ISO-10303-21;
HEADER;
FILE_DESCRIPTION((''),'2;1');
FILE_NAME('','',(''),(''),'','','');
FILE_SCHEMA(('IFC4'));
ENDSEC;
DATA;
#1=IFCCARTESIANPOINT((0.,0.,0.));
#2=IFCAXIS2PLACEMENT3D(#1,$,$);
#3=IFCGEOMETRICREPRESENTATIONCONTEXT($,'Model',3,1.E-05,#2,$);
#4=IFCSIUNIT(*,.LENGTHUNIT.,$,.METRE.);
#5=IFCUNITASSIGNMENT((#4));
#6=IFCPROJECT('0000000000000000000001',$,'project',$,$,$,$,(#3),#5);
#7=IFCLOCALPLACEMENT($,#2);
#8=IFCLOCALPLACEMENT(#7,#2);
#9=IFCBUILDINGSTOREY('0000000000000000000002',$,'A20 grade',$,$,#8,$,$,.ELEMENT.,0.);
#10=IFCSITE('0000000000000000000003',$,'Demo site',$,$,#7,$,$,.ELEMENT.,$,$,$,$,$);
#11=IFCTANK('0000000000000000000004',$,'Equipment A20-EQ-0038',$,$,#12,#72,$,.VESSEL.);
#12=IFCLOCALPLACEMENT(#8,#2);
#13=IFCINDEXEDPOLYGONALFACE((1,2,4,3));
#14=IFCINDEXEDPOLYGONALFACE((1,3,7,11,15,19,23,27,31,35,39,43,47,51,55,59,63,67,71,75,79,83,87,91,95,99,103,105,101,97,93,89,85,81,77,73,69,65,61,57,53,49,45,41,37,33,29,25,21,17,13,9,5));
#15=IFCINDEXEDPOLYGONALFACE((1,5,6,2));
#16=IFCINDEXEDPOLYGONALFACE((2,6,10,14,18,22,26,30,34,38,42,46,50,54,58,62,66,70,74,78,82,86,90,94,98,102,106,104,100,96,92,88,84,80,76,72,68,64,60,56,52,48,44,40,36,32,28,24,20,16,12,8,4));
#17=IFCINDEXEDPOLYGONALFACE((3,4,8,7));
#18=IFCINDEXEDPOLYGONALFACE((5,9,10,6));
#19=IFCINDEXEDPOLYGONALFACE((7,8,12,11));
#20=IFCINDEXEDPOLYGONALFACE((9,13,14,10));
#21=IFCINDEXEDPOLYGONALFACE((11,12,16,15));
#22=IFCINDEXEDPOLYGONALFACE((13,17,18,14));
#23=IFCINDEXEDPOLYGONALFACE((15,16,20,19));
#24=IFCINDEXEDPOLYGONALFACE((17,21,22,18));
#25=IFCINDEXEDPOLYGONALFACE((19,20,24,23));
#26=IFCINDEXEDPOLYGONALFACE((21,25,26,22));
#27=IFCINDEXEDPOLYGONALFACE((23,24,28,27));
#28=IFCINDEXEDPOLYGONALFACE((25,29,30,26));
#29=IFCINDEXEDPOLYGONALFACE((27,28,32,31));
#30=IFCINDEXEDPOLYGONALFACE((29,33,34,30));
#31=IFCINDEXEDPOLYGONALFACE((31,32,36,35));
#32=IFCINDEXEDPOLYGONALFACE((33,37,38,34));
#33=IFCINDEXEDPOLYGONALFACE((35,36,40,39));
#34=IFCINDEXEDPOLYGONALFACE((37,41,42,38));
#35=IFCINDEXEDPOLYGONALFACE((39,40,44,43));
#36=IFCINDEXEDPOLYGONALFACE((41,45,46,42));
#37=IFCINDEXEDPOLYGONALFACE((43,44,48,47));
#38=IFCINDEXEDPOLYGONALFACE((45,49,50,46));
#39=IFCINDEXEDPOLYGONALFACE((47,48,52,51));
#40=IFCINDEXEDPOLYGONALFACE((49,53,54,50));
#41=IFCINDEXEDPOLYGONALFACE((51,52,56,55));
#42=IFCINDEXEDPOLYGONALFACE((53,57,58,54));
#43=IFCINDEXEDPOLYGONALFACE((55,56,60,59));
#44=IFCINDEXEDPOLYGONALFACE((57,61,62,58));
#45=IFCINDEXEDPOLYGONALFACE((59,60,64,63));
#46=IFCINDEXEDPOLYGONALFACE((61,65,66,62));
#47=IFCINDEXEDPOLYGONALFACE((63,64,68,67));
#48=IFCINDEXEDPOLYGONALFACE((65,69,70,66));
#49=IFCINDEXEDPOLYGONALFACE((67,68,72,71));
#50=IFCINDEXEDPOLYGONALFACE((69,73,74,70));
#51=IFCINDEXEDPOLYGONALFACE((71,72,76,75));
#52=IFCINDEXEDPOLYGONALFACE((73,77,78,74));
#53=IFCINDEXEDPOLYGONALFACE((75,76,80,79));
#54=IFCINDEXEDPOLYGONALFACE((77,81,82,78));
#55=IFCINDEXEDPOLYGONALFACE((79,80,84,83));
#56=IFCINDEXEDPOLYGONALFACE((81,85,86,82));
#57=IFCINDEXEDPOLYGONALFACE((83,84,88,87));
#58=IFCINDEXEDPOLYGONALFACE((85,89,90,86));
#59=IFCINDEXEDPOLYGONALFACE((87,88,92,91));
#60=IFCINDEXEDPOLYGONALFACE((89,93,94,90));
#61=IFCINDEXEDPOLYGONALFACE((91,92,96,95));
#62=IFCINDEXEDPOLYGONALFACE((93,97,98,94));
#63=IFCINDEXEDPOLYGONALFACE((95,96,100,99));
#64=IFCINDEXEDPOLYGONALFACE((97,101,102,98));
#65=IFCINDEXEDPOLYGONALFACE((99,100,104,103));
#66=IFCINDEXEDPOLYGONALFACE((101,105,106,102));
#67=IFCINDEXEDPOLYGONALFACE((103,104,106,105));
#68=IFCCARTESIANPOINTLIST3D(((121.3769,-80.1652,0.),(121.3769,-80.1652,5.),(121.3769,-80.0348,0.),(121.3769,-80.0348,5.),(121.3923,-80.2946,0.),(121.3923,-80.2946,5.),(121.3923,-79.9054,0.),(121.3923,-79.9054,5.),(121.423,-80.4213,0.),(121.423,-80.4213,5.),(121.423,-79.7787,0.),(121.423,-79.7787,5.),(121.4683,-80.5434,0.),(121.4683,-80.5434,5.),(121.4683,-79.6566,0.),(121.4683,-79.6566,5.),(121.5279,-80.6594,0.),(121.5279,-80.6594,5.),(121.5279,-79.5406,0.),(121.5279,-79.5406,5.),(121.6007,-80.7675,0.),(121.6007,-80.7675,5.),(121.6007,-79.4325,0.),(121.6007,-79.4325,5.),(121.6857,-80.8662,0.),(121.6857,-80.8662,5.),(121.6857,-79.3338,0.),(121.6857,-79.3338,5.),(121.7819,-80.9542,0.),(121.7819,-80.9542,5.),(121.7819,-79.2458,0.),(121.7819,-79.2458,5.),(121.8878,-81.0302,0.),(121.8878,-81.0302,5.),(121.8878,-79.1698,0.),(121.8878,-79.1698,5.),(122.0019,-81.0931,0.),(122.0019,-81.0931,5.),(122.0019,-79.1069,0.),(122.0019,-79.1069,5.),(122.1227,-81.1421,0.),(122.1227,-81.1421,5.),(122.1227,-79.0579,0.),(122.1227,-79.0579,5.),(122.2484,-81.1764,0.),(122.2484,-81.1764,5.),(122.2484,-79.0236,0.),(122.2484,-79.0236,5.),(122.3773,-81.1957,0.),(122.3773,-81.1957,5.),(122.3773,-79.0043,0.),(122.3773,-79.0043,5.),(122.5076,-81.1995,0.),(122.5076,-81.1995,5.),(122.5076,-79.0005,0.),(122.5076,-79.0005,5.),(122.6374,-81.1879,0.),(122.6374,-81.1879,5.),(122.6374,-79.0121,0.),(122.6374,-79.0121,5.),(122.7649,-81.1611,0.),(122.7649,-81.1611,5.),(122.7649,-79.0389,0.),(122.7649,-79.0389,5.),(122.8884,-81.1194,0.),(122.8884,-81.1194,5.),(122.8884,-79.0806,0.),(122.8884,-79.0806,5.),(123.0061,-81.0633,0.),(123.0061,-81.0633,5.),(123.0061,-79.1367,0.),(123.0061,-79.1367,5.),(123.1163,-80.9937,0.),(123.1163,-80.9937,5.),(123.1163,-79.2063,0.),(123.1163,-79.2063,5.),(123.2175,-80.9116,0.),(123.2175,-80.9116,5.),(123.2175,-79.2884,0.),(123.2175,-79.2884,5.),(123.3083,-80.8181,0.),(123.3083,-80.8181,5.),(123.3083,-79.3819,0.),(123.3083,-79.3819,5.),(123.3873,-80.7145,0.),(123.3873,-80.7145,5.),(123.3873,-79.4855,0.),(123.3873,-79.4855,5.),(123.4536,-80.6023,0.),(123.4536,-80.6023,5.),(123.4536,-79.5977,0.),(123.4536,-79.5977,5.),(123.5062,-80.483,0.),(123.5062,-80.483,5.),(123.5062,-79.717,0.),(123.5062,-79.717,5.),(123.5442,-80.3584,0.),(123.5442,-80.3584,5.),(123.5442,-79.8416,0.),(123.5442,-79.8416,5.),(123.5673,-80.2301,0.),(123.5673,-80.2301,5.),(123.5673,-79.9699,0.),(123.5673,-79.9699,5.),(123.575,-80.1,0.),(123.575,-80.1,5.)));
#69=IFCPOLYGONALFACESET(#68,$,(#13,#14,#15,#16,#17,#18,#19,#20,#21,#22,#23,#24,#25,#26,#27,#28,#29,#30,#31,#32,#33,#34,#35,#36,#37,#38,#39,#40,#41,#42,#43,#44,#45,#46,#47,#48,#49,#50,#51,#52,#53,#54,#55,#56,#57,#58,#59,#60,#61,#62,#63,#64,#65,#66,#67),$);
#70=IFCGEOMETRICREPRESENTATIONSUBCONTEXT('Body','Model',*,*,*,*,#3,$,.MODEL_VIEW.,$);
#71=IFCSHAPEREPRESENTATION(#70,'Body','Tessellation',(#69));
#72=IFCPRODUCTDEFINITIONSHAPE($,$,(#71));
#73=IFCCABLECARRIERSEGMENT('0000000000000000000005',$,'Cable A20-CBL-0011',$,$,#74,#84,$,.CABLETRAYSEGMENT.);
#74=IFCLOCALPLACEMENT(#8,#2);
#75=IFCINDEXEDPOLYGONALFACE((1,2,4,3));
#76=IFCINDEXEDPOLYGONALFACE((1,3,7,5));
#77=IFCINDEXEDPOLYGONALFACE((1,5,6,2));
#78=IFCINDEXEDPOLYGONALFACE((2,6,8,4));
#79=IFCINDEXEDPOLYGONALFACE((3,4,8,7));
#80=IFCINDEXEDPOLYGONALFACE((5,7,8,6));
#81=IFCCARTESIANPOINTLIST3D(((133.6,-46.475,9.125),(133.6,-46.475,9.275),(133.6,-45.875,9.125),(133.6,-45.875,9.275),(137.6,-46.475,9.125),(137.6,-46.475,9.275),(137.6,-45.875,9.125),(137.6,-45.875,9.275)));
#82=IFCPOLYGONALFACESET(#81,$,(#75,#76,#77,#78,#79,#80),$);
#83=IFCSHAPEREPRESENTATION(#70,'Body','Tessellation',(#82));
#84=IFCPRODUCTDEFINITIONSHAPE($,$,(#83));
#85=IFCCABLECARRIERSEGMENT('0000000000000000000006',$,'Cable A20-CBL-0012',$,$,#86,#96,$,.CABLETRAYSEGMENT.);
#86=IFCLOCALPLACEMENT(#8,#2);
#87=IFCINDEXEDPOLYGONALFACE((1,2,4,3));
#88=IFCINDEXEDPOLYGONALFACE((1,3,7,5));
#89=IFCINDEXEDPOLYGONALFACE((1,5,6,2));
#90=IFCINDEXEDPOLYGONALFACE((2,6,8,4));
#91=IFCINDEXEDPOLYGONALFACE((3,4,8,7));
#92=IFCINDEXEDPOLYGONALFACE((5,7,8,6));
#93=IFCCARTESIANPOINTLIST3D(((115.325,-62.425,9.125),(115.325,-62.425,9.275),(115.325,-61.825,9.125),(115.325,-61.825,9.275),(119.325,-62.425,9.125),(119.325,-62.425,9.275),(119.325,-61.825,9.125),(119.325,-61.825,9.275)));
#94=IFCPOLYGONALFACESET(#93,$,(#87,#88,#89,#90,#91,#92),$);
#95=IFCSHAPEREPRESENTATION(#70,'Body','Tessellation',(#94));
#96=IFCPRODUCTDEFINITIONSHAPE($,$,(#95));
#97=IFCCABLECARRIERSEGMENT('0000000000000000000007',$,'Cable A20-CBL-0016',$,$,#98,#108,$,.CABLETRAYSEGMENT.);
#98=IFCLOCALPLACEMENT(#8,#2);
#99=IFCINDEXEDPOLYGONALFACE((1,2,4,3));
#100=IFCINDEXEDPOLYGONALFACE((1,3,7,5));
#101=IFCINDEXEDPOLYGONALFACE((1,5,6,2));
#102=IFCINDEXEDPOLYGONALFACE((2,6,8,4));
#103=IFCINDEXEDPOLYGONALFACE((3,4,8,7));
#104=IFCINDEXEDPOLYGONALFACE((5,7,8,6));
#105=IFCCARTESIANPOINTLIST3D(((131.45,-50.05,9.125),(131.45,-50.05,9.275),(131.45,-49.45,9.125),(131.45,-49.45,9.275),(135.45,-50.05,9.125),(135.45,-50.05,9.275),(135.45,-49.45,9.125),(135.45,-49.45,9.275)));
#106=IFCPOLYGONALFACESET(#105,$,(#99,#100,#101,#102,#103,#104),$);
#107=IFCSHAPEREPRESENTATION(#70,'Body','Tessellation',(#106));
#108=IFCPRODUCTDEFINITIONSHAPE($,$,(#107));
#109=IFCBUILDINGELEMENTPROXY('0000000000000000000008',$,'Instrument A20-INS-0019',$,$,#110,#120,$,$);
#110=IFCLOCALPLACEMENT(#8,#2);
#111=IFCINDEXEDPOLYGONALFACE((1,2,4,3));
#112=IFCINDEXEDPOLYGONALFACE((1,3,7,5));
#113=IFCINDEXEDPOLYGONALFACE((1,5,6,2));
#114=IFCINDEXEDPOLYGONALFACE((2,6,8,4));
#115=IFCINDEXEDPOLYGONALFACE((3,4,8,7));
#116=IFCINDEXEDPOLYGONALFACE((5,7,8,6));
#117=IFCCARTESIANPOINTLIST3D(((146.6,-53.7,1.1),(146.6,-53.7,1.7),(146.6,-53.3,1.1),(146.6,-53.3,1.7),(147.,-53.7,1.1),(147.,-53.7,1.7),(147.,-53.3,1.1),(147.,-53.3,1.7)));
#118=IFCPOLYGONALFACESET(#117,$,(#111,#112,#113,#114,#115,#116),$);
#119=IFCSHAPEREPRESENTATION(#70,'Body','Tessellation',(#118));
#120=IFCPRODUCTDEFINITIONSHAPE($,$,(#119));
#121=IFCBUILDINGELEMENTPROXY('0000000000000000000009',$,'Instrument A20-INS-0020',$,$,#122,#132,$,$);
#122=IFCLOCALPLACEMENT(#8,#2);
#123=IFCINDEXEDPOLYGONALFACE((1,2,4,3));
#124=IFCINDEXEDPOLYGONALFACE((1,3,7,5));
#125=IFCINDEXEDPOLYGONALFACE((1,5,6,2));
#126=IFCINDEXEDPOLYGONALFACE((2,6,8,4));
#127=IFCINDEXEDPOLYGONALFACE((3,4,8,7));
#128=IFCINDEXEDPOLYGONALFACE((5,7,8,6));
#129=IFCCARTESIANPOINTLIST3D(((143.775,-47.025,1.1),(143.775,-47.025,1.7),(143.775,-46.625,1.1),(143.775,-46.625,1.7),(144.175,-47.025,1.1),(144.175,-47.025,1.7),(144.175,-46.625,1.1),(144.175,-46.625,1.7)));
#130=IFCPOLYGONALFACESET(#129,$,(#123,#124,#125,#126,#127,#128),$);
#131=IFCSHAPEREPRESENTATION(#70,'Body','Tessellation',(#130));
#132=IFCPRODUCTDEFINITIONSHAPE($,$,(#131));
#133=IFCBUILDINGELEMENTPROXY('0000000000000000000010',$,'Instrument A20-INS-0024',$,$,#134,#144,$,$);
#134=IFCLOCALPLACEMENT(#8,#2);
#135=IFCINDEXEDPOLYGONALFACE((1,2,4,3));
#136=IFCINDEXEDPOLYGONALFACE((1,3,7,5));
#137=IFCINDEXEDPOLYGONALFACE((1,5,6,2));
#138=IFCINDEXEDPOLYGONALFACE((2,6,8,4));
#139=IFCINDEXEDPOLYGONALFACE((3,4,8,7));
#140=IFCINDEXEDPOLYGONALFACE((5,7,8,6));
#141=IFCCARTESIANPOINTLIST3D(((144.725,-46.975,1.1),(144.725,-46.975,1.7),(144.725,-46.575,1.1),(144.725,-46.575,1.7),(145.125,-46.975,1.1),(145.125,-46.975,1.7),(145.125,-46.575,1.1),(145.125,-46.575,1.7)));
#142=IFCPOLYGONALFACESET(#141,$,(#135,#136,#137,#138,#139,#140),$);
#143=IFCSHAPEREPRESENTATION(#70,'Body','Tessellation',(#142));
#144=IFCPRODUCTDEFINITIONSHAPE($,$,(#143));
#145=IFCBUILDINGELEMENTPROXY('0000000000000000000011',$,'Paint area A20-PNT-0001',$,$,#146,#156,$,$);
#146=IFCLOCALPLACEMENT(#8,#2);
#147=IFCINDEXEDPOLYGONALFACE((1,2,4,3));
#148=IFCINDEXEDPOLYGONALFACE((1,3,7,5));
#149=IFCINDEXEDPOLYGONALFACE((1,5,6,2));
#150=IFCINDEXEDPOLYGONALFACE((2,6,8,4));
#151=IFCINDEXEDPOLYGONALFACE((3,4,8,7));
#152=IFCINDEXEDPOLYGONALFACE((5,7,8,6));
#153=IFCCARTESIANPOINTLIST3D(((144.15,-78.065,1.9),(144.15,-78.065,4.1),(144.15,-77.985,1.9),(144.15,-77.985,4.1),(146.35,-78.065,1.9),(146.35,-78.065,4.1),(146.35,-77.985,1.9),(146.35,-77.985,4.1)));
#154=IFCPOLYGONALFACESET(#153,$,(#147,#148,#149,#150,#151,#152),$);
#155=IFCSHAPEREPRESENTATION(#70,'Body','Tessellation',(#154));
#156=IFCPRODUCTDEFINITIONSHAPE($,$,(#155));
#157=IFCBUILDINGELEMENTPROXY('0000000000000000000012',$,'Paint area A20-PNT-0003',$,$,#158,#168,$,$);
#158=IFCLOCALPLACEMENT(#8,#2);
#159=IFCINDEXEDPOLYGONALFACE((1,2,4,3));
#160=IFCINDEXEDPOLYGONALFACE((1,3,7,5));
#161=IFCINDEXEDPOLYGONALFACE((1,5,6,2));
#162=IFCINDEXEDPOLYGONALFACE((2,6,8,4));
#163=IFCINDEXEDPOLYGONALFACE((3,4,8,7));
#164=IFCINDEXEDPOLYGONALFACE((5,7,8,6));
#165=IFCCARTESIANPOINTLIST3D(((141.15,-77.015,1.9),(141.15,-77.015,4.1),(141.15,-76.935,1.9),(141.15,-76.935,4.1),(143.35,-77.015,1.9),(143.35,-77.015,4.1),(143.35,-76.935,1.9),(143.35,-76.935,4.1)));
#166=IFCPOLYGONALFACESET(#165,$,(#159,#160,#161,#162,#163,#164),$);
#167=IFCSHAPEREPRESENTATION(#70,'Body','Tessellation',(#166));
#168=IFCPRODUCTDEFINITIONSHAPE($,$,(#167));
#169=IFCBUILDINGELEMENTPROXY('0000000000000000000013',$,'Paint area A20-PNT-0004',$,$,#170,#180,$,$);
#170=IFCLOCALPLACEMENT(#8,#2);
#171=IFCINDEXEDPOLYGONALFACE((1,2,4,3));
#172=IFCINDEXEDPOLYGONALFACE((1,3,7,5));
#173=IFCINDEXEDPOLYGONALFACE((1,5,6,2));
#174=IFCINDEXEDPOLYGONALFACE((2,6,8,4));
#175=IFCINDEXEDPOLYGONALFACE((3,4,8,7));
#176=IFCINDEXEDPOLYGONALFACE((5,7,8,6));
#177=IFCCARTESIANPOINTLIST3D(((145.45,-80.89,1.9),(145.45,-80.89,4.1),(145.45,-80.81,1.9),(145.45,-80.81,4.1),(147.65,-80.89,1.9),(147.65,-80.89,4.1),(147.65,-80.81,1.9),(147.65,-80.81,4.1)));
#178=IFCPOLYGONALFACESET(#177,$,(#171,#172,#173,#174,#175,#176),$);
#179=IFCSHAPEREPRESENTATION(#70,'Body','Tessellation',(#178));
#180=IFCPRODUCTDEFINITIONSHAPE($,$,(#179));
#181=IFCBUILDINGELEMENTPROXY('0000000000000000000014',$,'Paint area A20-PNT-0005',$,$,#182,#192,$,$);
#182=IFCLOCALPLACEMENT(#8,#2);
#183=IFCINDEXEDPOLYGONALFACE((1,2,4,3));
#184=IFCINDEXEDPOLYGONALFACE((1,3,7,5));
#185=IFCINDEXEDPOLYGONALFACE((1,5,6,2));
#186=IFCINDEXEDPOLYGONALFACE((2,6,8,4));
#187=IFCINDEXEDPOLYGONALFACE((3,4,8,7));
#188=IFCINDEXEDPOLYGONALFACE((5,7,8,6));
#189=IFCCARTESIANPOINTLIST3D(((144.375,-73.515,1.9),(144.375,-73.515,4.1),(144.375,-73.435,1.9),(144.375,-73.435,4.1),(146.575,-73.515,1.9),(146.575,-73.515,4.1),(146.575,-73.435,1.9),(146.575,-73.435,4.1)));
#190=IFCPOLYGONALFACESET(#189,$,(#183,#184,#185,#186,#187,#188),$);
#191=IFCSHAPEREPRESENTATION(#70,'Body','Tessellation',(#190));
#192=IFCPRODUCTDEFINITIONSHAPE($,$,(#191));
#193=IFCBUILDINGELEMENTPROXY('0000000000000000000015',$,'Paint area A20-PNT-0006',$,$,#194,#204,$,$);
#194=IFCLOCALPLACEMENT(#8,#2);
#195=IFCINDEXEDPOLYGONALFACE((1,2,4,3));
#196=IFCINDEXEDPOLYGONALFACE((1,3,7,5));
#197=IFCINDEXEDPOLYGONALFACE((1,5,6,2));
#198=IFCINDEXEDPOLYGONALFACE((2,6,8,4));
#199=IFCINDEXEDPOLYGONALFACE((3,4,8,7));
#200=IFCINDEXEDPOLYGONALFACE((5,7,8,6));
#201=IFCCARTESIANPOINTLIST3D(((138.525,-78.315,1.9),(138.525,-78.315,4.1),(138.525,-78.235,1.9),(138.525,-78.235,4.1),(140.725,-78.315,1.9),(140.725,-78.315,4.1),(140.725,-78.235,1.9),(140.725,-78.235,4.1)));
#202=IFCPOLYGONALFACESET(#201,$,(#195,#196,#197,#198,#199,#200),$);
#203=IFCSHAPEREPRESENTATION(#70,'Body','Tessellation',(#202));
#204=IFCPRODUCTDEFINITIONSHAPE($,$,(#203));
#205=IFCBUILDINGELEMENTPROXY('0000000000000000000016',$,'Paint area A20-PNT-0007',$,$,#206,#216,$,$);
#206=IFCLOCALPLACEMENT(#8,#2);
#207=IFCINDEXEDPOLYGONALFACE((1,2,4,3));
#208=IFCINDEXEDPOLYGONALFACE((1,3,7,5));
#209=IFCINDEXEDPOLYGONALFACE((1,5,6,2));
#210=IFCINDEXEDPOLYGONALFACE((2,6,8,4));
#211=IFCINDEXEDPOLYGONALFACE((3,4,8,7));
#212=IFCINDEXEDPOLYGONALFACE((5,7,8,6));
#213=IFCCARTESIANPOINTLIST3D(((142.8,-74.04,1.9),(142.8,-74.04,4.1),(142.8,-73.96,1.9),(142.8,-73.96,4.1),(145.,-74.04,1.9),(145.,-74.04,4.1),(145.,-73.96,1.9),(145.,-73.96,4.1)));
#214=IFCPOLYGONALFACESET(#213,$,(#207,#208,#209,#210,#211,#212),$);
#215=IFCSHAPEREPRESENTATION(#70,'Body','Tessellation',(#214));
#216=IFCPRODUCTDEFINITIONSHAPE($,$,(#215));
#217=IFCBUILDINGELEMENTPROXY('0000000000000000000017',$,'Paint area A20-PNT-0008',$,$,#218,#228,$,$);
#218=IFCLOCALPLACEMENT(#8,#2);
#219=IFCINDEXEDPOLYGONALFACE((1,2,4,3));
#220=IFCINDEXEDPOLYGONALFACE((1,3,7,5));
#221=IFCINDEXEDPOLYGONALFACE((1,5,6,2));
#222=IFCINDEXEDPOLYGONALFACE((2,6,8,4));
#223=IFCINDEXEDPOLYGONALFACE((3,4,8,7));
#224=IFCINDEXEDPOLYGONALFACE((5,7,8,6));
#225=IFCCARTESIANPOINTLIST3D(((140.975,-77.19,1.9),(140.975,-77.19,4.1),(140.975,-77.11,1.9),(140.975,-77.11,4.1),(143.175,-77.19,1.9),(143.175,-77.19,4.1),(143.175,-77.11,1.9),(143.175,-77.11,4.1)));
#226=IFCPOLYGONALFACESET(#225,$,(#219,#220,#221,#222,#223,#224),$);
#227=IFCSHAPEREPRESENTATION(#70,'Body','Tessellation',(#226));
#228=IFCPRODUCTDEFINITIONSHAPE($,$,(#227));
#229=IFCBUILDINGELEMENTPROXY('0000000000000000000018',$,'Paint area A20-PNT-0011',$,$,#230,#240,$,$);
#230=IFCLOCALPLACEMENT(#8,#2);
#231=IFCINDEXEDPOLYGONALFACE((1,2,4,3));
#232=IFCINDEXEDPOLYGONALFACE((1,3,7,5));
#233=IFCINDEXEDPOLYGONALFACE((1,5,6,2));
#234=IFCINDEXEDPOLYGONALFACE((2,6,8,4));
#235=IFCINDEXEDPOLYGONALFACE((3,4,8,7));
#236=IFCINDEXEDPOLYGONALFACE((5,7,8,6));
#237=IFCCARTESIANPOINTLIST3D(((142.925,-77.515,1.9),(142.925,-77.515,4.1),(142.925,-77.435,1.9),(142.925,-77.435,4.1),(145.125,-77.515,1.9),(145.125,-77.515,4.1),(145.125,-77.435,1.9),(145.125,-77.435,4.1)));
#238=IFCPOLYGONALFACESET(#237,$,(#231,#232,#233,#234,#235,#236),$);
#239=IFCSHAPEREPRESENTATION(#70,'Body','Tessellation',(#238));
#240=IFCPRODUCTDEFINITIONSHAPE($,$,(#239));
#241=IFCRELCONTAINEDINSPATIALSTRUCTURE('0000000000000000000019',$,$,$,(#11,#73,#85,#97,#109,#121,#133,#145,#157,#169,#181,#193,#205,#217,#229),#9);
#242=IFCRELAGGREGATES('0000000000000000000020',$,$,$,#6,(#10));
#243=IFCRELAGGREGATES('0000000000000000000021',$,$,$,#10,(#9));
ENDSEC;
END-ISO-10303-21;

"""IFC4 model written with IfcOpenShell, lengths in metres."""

from ifc_helpers import new_model, si_unit, frame, origin, place, context, subcontext, project, spatial, rectangle, circle, extrude, element, save


model = new_model("IFC4")

# Units and contexts
model_context = context("Model", 3, precision=1e-05, world=origin())
body_context = subcontext(model_context, "Body", "Model", "MODEL_VIEW")
ifc_project = project(units=[si_unit("LENGTHUNIT", "METRE")], contexts=[model_context])

# Site, storey
site_placement = place(None, origin())
site = spatial("IfcSite", under=ifc_project, at=site_placement, Name="Demo site", CompositionType="ELEMENT")
storey_placement = place(site_placement, origin())
storey = spatial("IfcBuildingStorey", under=site, at=storey_placement, Name="A20 grade", CompositionType="ELEMENT", Elevation=0.0)

# Tank
for number, where, name in (
    (1, (122.475, -80.1, 0.0), "Equipment A20-EQ-0038"),
):
    element("IfcTank", number, at=place(storey_placement, frame(where)), inside=storey, Name=name, PredefinedType="VESSEL", context=body_context, shape_type="SweptSolid", body=[
        extrude(circle(Radius=1.1), origin(), (0.0, 0.0, 1.0), 5.0),
    ])

# Cable carrier segments
for number, where, name in (
    (2, (133.6, -46.175, 9.2), "Cable A20-CBL-0011"),
    (3, (115.325, -62.125, 9.2), "Cable A20-CBL-0012"),
    (4, (131.45, -49.75, 9.2), "Cable A20-CBL-0016"),
):
    element("IfcCableCarrierSegment", number, at=place(storey_placement, frame(where)), inside=storey, Name=name, PredefinedType="CABLETRAYSEGMENT", context=body_context, shape_type="SweptSolid", body=[
        extrude(rectangle(XDim=0.6, YDim=0.15), frame((0.0, 0.0, 0.0), z_axis=(1.0, 0.0, 0.0), x_axis=(0.0, 1.0, 0.0)), (0.0, 0.0, 1.0), 4.0),
    ])

# Building element proxies
for number, where, name in (
    (5, (146.8, -53.5, 1.1), "Instrument A20-INS-0019"),
    (6, (143.975, -46.825, 1.1), "Instrument A20-INS-0020"),
    (7, (144.925, -46.775, 1.1), "Instrument A20-INS-0024"),
):
    element("IfcBuildingElementProxy", number, at=place(storey_placement, frame(where)), inside=storey, Name=name, context=body_context, shape_type="SweptSolid", body=[
        extrude(rectangle(XDim=0.4, YDim=0.4), origin(), (0.0, 0.0, 1.0), 0.6),
    ])
for number, where, name in (
    (8, (145.25, -78.025, 1.9), "Paint area A20-PNT-0001"),
    (9, (142.25, -76.975, 1.9), "Paint area A20-PNT-0003"),
    (10, (146.55, -80.85, 1.9), "Paint area A20-PNT-0004"),
    (11, (145.475, -73.475, 1.9), "Paint area A20-PNT-0005"),
    (12, (139.625, -78.275, 1.9), "Paint area A20-PNT-0006"),
    (13, (143.9, -74.0, 1.9), "Paint area A20-PNT-0007"),
    (14, (142.075, -77.15, 1.9), "Paint area A20-PNT-0008"),
    (15, (144.025, -77.475, 1.9), "Paint area A20-PNT-0011"),
):
    element("IfcBuildingElementProxy", number, at=place(storey_placement, frame(where)), inside=storey, Name=name, context=body_context, shape_type="SweptSolid", body=[
        extrude(rectangle(XDim=2.2, YDim=0.08), origin(), (0.0, 0.0, 1.0), 2.2),
    ])

save(model, "model.ifc")
